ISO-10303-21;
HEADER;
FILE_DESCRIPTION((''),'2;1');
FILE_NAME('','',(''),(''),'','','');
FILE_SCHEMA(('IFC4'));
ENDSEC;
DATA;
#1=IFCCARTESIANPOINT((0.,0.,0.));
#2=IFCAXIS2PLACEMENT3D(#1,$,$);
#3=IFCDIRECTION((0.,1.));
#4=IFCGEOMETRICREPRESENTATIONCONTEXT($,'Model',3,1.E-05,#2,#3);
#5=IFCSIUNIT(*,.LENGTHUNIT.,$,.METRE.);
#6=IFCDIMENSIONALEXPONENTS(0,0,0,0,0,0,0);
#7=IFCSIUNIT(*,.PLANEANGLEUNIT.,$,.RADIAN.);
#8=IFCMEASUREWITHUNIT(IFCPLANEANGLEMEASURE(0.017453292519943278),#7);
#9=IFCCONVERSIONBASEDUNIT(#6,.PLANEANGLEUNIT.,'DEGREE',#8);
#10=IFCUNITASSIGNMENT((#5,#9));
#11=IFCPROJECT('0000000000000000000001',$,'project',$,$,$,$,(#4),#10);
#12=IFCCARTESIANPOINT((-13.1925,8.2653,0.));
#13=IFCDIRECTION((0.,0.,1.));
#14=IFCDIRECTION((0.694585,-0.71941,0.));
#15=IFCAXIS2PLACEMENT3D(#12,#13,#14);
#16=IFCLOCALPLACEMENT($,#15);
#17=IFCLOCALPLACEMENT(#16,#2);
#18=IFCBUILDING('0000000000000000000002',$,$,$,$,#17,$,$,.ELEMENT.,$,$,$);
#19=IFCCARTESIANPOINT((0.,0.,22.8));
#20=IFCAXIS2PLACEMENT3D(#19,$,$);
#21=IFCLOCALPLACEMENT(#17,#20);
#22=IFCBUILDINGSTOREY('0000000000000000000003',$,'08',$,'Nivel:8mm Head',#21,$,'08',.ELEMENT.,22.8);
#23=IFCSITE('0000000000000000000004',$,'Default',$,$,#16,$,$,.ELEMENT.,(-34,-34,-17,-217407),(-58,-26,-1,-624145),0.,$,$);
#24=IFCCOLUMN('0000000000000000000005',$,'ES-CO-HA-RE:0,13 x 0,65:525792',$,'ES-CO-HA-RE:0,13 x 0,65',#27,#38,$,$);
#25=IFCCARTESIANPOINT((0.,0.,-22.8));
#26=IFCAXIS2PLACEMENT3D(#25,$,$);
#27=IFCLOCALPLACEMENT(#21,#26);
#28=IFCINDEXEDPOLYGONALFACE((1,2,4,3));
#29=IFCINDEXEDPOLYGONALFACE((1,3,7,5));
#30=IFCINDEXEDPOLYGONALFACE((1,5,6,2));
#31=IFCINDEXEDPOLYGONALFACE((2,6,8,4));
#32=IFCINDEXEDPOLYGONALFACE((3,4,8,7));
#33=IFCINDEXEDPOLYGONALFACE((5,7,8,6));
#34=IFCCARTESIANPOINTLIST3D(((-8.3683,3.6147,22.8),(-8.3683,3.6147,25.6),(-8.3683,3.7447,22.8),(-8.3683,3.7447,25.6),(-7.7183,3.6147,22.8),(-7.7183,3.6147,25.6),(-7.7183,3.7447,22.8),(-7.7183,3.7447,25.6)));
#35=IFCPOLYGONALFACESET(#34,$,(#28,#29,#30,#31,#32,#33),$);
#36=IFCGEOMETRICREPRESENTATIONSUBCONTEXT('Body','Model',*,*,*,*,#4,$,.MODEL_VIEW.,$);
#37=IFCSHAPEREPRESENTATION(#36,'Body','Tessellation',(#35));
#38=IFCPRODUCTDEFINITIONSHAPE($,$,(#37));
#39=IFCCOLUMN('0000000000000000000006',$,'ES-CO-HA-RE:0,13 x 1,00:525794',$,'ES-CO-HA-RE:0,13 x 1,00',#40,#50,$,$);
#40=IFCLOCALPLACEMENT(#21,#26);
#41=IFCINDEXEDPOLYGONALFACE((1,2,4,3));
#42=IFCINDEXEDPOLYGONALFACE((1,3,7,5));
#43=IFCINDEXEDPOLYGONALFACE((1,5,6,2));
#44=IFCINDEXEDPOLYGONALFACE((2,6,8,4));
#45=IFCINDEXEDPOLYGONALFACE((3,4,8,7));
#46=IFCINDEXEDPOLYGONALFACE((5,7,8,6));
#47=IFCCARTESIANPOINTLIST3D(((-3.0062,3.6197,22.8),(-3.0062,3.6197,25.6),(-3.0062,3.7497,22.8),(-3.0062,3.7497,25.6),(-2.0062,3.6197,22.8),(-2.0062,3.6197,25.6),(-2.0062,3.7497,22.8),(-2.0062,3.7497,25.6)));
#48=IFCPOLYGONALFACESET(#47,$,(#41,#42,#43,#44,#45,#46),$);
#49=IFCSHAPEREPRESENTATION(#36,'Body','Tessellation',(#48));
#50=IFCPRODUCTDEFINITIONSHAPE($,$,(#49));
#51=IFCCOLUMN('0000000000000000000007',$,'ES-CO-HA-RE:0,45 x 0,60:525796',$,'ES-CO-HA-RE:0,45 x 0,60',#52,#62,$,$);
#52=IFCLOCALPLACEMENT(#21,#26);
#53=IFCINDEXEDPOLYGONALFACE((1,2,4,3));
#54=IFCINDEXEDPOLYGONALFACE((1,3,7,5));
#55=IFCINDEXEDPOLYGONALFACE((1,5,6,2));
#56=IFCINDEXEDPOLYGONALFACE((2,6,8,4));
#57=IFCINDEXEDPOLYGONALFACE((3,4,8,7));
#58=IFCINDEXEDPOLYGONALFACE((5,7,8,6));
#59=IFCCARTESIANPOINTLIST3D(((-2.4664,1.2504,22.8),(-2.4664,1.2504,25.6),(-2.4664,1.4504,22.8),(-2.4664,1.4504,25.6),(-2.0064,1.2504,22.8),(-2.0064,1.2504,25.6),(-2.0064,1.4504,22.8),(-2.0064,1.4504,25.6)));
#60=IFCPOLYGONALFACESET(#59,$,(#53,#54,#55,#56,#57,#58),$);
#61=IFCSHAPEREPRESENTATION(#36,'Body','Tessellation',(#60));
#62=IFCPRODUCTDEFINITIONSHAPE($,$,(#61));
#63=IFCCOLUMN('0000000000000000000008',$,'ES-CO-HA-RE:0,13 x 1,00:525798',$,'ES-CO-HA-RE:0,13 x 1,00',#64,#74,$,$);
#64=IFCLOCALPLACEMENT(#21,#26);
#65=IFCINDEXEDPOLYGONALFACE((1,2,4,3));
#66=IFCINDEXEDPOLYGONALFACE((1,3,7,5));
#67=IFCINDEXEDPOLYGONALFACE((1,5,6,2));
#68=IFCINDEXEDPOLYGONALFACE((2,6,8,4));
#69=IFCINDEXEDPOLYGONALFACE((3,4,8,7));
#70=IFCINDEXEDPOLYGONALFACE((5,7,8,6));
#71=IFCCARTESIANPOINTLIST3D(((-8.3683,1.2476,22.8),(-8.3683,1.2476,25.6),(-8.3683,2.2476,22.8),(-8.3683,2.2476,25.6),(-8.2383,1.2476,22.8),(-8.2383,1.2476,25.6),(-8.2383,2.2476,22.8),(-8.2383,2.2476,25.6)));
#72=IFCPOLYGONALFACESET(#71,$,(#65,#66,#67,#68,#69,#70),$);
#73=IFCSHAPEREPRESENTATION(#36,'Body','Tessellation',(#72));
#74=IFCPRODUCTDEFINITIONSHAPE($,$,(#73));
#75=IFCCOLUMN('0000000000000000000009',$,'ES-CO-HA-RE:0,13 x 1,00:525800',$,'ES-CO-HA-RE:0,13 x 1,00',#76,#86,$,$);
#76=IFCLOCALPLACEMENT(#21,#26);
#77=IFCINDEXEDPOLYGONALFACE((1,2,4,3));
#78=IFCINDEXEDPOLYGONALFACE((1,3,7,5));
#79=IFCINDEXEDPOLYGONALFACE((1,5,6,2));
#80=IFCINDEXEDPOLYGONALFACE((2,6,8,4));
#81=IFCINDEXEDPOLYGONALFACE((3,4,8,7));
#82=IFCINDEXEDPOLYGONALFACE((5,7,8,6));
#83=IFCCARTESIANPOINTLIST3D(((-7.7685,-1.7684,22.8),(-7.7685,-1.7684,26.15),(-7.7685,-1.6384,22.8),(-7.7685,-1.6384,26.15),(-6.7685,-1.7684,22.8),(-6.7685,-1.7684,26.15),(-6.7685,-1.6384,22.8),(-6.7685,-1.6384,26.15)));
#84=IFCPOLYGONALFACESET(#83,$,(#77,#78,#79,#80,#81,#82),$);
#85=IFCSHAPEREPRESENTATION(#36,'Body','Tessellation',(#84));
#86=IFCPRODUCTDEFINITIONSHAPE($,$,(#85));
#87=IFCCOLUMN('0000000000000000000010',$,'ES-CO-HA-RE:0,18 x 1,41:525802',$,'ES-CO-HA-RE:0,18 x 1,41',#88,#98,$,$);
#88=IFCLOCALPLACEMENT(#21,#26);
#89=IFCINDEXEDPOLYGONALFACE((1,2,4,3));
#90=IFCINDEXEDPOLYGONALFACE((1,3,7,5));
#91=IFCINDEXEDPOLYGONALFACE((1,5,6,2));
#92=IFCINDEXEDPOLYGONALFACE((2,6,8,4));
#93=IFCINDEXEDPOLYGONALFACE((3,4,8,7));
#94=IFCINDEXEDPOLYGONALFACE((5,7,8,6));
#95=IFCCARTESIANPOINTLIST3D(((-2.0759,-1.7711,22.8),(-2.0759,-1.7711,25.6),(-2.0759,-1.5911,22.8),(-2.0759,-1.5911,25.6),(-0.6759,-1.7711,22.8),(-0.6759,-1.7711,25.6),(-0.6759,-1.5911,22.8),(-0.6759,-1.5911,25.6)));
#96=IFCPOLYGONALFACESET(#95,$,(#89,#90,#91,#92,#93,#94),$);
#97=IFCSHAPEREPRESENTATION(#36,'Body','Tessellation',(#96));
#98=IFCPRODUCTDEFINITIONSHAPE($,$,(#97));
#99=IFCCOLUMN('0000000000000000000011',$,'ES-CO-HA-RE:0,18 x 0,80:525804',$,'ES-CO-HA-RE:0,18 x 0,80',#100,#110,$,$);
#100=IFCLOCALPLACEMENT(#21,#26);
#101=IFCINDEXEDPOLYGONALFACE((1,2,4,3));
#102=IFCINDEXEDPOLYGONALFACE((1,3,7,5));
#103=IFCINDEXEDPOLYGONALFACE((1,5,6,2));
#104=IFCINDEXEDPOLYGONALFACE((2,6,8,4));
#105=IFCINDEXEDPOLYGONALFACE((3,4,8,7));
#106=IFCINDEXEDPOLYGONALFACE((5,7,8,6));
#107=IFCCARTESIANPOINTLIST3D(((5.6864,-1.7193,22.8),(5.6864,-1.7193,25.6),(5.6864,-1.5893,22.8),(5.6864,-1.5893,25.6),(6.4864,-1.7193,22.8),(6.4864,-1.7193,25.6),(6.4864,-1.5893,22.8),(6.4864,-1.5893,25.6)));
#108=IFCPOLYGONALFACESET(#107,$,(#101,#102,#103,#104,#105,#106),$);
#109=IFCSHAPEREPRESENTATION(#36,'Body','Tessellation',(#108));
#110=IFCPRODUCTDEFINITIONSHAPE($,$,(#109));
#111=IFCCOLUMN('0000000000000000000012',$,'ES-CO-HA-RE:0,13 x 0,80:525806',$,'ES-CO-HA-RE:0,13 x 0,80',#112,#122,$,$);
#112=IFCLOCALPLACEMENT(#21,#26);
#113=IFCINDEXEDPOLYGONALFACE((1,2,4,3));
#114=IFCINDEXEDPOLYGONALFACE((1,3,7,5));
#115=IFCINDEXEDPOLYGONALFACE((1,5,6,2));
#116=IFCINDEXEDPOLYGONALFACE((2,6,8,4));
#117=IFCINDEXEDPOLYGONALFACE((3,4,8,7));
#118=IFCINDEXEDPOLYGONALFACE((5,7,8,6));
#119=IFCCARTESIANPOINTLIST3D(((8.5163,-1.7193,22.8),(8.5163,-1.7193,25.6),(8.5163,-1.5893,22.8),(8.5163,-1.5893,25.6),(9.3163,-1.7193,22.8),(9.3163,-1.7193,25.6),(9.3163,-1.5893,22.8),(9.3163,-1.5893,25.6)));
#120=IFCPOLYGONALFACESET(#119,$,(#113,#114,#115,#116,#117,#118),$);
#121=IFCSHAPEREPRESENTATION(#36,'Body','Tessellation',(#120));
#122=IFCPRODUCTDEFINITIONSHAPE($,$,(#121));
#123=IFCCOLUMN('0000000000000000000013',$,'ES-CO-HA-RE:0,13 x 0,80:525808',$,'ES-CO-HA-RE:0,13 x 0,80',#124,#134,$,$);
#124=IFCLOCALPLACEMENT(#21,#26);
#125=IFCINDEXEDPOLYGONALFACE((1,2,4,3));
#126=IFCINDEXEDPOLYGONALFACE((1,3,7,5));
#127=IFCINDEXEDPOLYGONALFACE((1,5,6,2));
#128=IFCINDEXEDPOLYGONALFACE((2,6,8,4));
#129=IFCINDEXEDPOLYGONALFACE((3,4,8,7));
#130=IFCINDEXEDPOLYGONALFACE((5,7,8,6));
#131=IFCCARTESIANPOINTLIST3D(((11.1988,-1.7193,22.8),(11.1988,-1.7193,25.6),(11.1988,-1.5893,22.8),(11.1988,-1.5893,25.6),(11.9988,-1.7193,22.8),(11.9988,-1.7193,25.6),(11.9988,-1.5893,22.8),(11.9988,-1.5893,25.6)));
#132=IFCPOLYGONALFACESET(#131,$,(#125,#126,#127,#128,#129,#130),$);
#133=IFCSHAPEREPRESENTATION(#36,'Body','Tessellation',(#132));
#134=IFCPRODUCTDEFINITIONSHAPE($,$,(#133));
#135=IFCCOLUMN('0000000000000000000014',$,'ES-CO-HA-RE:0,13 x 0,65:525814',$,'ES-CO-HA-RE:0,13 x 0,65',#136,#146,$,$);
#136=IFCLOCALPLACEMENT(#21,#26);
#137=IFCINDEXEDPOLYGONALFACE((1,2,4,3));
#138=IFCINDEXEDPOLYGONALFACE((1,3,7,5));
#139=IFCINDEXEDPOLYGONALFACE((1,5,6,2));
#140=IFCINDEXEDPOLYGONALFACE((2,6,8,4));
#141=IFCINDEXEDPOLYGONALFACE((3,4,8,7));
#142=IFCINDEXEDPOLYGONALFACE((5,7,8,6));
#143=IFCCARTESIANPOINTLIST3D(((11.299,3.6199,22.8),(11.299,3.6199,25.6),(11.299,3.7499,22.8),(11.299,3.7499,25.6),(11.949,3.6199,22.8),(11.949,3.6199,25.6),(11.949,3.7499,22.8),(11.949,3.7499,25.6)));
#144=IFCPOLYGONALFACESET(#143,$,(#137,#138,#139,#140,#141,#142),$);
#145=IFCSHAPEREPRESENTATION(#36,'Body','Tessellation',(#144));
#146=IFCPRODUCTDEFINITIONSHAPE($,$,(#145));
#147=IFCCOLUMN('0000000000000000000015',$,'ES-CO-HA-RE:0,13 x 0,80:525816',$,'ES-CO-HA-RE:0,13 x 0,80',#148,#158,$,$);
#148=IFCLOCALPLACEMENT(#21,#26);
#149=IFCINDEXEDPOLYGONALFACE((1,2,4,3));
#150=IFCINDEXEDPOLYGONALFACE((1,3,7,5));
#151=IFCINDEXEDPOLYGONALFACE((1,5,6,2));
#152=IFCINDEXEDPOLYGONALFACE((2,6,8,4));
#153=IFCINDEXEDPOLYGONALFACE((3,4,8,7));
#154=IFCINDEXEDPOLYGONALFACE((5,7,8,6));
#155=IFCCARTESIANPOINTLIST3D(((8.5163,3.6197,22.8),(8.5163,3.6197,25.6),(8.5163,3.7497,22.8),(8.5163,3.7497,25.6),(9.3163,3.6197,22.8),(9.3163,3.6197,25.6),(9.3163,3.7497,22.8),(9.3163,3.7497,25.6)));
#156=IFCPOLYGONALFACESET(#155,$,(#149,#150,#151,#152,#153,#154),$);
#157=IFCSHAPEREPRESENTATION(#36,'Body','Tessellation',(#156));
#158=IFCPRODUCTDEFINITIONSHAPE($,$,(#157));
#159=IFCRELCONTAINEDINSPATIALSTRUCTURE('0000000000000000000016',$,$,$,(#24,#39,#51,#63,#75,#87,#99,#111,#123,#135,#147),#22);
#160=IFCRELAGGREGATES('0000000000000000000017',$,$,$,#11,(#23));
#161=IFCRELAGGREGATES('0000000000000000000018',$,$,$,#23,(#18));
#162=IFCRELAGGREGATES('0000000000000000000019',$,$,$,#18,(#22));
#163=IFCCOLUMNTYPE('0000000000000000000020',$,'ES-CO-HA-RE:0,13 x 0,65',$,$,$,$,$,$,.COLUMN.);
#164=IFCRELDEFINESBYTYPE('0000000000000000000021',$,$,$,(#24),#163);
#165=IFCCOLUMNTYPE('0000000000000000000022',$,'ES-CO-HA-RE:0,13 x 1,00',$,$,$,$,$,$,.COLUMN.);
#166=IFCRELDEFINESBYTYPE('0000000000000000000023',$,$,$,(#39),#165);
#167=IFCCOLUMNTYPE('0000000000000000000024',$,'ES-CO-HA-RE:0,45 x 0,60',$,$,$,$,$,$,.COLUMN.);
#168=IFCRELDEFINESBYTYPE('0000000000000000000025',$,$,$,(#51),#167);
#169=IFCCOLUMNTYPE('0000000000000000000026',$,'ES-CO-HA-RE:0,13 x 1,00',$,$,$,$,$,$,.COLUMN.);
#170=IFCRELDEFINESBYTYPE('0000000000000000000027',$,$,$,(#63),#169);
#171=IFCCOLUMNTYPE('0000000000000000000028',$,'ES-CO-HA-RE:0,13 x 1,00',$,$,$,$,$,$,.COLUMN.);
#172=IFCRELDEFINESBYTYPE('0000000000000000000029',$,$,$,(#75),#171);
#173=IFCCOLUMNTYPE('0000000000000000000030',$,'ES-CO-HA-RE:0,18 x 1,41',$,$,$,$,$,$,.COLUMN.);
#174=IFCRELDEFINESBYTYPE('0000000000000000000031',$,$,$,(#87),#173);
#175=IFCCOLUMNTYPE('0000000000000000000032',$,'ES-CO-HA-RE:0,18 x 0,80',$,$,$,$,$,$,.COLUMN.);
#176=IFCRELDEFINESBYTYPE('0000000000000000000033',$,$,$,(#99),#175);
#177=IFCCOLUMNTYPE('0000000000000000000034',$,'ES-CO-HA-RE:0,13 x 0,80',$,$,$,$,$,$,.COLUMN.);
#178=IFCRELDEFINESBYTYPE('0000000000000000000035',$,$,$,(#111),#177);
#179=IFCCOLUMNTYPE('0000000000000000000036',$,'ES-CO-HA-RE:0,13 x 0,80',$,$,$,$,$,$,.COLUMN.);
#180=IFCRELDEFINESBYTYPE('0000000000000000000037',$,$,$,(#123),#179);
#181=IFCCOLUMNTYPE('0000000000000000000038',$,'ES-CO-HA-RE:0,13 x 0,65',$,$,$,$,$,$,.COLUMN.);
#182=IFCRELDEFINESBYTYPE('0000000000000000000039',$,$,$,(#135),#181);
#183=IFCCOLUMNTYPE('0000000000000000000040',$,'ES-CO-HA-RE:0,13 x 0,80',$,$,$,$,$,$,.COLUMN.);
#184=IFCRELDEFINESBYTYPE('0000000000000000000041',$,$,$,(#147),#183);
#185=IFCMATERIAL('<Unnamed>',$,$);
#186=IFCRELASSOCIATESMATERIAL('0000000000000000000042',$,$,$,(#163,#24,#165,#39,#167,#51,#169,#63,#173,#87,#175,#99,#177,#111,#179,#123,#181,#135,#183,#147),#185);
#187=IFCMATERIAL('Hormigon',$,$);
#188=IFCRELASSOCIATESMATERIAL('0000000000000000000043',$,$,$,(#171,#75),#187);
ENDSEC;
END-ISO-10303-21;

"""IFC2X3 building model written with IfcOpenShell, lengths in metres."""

from ifc_helpers import new_model, entity, si_unit, converted_unit, direction, frame, frame_2d, origin, origin_2d_with_axis, place, context, subcontext, project, spatial, rectangle, extrude, source, transform, mapped, material, type_object, type_shapes, element, save


model = new_model("IFC2X3")

# Units and contexts
model_context = context("Model", 3, precision=1e-05, world=origin(), true_north=direction((0.0, 1.0)))
body_context = subcontext(model_context, "Body", "Model", "MODEL_VIEW")
ifc_project = project(units=[si_unit("LENGTHUNIT", "METRE"), converted_unit("PLANEANGLEUNIT", "DEGREE", entity("IfcPlaneAngleMeasure", 0.017453292519943278), si_unit("PLANEANGLEUNIT", "RADIAN"), dimensions=[0, 0, 0, 0, 0, 0, 0])], contexts=[model_context])

# Site, building, storey
site_placement = place(None, frame((-13.1925, 8.2653, 0.0), z_axis=(0.0, 0.0, 1.0), x_axis=(0.694585, -0.71941, 0.0)))
site = spatial("IfcSite", under=ifc_project, at=site_placement, Name="Default", CompositionType="ELEMENT", RefLatitude=(-34, -34, -17, -217407), RefLongitude=(-58, -26, -1, -624145), RefElevation=0.0)
building_placement = place(site_placement, origin())
building = spatial("IfcBuilding", under=site, at=building_placement, CompositionType="ELEMENT")
storey_placement = place(building_placement, frame((0.0, 0.0, 22.8)))
storey = spatial("IfcBuildingStorey", under=building, at=storey_placement, Name="08", ObjectType="Nivel:8mm Head", LongName="08", CompositionType="ELEMENT", Elevation=22.8)

# Columns
ifc_material_1 = material(Name="<Unnamed>")
column_type_1 = type_object("IfcColumnType", Name="ES-CO-HA-RE:0,13 x 0,65", PredefinedType="COLUMN", material=ifc_material_1)
shared_shape_1 = source(origin(), body_context, "Body", "SweptSolid", [
    extrude(rectangle(XDim=0.65, YDim=0.13, at=origin_2d_with_axis()), frame((-8.0433, 3.6797, 22.8), z_axis=(0.0, 0.0, 1.0), x_axis=(-1.0, 0.0, 0.0)), (0.0, 0.0, 1.0), 2.8),
])
type_shapes(column_type_1, [shared_shape_1])
column_1_placement = place(storey_placement, frame((0.0, 0.0, -22.8)))
element("IfcColumn", 1, at=column_1_placement, inside=storey, type_object=column_type_1, material=ifc_material_1, Name="ES-CO-HA-RE:0,13 x 0,65:525792", ObjectType="ES-CO-HA-RE:0,13 x 0,65", context=body_context, shape_type="MappedRepresentation", body=[
    mapped(shared_shape_1, transform((0.0, 0.0, 0.0), scale=1.0)),
])
column_type_2 = type_object("IfcColumnType", Name="ES-CO-HA-RE:0,13 x 1,00", PredefinedType="COLUMN", material=ifc_material_1)
shared_shape_2 = source(origin(), body_context, "Body", "SweptSolid", [
    extrude(rectangle(XDim=1.0, YDim=0.13, at=frame_2d((0.0, 0.0), x_axis=(1.0, 0.0))), frame((-2.5062, 3.6847, 22.8), z_axis=(0.0, 0.0, 1.0), x_axis=(-1.0, 0.0, 0.0)), (0.0, 0.0, 1.0), 2.8),
])
type_shapes(column_type_2, [shared_shape_2])
column_2_placement = place(storey_placement, frame((0.0, 0.0, -22.8)))
element("IfcColumn", 2, at=column_2_placement, inside=storey, type_object=column_type_2, material=ifc_material_1, Name="ES-CO-HA-RE:0,13 x 1,00:525794", ObjectType="ES-CO-HA-RE:0,13 x 1,00", context=body_context, shape_type="MappedRepresentation", body=[
    mapped(shared_shape_2, transform((0.0, 0.0, 0.0), scale=1.0)),
])
column_type_3 = type_object("IfcColumnType", Name="ES-CO-HA-RE:0,45 x 0,60", PredefinedType="COLUMN", material=ifc_material_1)
shared_shape_3 = source(origin(), body_context, "Body", "SweptSolid", [
    extrude(rectangle(XDim=0.46, YDim=0.2, at=frame_2d((0.0, 0.0), x_axis=(1.0, 0.0))), frame((-2.2364, 1.3504, 22.8), z_axis=(0.0, 0.0, 1.0), x_axis=(-1.0, 0.0, 0.0)), (0.0, 0.0, 1.0), 2.8),
])
type_shapes(column_type_3, [shared_shape_3])
column_3_placement = place(storey_placement, frame((0.0, 0.0, -22.8)))
element("IfcColumn", 3, at=column_3_placement, inside=storey, type_object=column_type_3, material=ifc_material_1, Name="ES-CO-HA-RE:0,45 x 0,60:525796", ObjectType="ES-CO-HA-RE:0,45 x 0,60", context=body_context, shape_type="MappedRepresentation", body=[
    mapped(shared_shape_3, transform((0.0, 0.0, 0.0), scale=1.0)),
])
column_type_4 = type_object("IfcColumnType", Name="ES-CO-HA-RE:0,13 x 1,00", PredefinedType="COLUMN", material=ifc_material_1)
shared_shape_4 = source(origin(), body_context, "Body", "SweptSolid", [
    extrude(rectangle(XDim=1.0, YDim=0.13, at=frame_2d((0.0, 0.0), x_axis=(1.0, 0.0))), frame((-8.3033, 1.7476, 22.8), z_axis=(0.0, 0.0, 1.0), x_axis=(0.0, -1.0, 0.0)), (0.0, 0.0, 1.0), 2.8),
])
type_shapes(column_type_4, [shared_shape_4])
column_4_placement = place(storey_placement, frame((0.0, 0.0, -22.8)))
element("IfcColumn", 4, at=column_4_placement, inside=storey, type_object=column_type_4, material=ifc_material_1, Name="ES-CO-HA-RE:0,13 x 1,00:525798", ObjectType="ES-CO-HA-RE:0,13 x 1,00", context=body_context, shape_type="MappedRepresentation", body=[
    mapped(shared_shape_4, transform((0.0, 0.0, 0.0), scale=1.0)),
])
ifc_material_2 = material(Name="Hormigon")
column_type_5 = type_object("IfcColumnType", Name="ES-CO-HA-RE:0,13 x 1,00", PredefinedType="COLUMN", material=ifc_material_2)
shared_shape_5 = source(origin(), body_context, "Body", "SweptSolid", [
    extrude(rectangle(XDim=1.0, YDim=0.13, at=frame_2d((0.0, 0.0), x_axis=(1.0, 0.0))), frame((-7.2685, -1.7034, 22.8), z_axis=(0.0, 0.0, 1.0), x_axis=(-1.0, 0.0, 0.0)), (0.0, 0.0, 1.0), 3.35),
])
type_shapes(column_type_5, [shared_shape_5])
column_5_placement = place(storey_placement, frame((0.0, 0.0, -22.8)))
element("IfcColumn", 5, at=column_5_placement, inside=storey, type_object=column_type_5, material=ifc_material_2, Name="ES-CO-HA-RE:0,13 x 1,00:525800", ObjectType="ES-CO-HA-RE:0,13 x 1,00", context=body_context, shape_type="MappedRepresentation", body=[
    mapped(shared_shape_5, transform((0.0, 0.0, 0.0), scale=1.0)),
])
column_type_6 = type_object("IfcColumnType", Name="ES-CO-HA-RE:0,18 x 1,41", PredefinedType="COLUMN", material=ifc_material_1)
shared_shape_6 = source(origin(), body_context, "Body", "SweptSolid", [
    extrude(rectangle(XDim=1.4, YDim=0.18, at=frame_2d((0.0, 0.0), x_axis=(1.0, 0.0))), frame((-1.3759, -1.6811, 22.8), z_axis=(0.0, 0.0, 1.0), x_axis=(-1.0, 0.0, 0.0)), (0.0, 0.0, 1.0), 2.8),
])
type_shapes(column_type_6, [shared_shape_6])
column_6_placement = place(storey_placement, frame((0.0, 0.0, -22.8)))
element("IfcColumn", 6, at=column_6_placement, inside=storey, type_object=column_type_6, material=ifc_material_1, Name="ES-CO-HA-RE:0,18 x 1,41:525802", ObjectType="ES-CO-HA-RE:0,18 x 1,41", context=body_context, shape_type="MappedRepresentation", body=[
    mapped(shared_shape_6, transform((0.0, 0.0, 0.0), scale=1.0)),
])
column_type_7 = type_object("IfcColumnType", Name="ES-CO-HA-RE:0,18 x 0,80", PredefinedType="COLUMN", material=ifc_material_1)
shared_shape_7 = source(origin(), body_context, "Body", "SweptSolid", [
    extrude(rectangle(XDim=0.8, YDim=0.13, at=frame_2d((0.0, 0.0), x_axis=(1.0, 0.0))), frame((6.0864, -1.6543, 22.8), z_axis=(0.0, 0.0, 1.0), x_axis=(-1.0, 0.0, 0.0)), (0.0, 0.0, 1.0), 2.8),
])
type_shapes(column_type_7, [shared_shape_7])
column_7_placement = place(storey_placement, frame((0.0, 0.0, -22.8)))
element("IfcColumn", 7, at=column_7_placement, inside=storey, type_object=column_type_7, material=ifc_material_1, Name="ES-CO-HA-RE:0,18 x 0,80:525804", ObjectType="ES-CO-HA-RE:0,18 x 0,80", context=body_context, shape_type="MappedRepresentation", body=[
    mapped(shared_shape_7, transform((0.0, 0.0, 0.0), scale=1.0)),
])
column_type_8 = type_object("IfcColumnType", Name="ES-CO-HA-RE:0,13 x 0,80", PredefinedType="COLUMN", material=ifc_material_1)
shared_shape_8 = source(origin(), body_context, "Body", "SweptSolid", [
    extrude(rectangle(XDim=0.8, YDim=0.13, at=frame_2d((0.0, 0.0), x_axis=(1.0, 0.0))), frame((8.9163, -1.6543, 22.8), z_axis=(0.0, 0.0, 1.0), x_axis=(-1.0, 0.0, 0.0)), (0.0, 0.0, 1.0), 2.8),
])
type_shapes(column_type_8, [shared_shape_8])
column_8_placement = place(storey_placement, frame((0.0, 0.0, -22.8)))
element("IfcColumn", 8, at=column_8_placement, inside=storey, type_object=column_type_8, material=ifc_material_1, Name="ES-CO-HA-RE:0,13 x 0,80:525806", ObjectType="ES-CO-HA-RE:0,13 x 0,80", context=body_context, shape_type="MappedRepresentation", body=[
    mapped(shared_shape_8, transform((0.0, 0.0, 0.0), scale=1.0)),
])
column_type_9 = type_object("IfcColumnType", Name="ES-CO-HA-RE:0,13 x 0,80", PredefinedType="COLUMN", material=ifc_material_1)
shared_shape_9 = source(origin(), body_context, "Body", "SweptSolid", [
    extrude(rectangle(XDim=0.8, YDim=0.13, at=frame_2d((0.0, 0.0), x_axis=(1.0, 0.0))), frame((11.5988, -1.6543, 22.8), z_axis=(0.0, 0.0, 1.0), x_axis=(-1.0, 0.0, 0.0)), (0.0, 0.0, 1.0), 2.8),
])
type_shapes(column_type_9, [shared_shape_9])
column_9_placement = place(storey_placement, frame((0.0, 0.0, -22.8)))
element("IfcColumn", 9, at=column_9_placement, inside=storey, type_object=column_type_9, material=ifc_material_1, Name="ES-CO-HA-RE:0,13 x 0,80:525808", ObjectType="ES-CO-HA-RE:0,13 x 0,80", context=body_context, shape_type="MappedRepresentation", body=[
    mapped(shared_shape_9, transform((0.0, 0.0, 0.0), scale=1.0)),
])
column_type_10 = type_object("IfcColumnType", Name="ES-CO-HA-RE:0,13 x 0,65", PredefinedType="COLUMN", material=ifc_material_1)
shared_shape_10 = source(origin(), body_context, "Body", "SweptSolid", [
    extrude(rectangle(XDim=0.65, YDim=0.13, at=frame_2d((0.0, 0.0), x_axis=(1.0, 0.0))), frame((11.624, 3.6849, 22.8), z_axis=(0.0, 0.0, 1.0), x_axis=(-1.0, 0.0, 0.0)), (0.0, 0.0, 1.0), 2.8),
])
type_shapes(column_type_10, [shared_shape_10])
column_10_placement = place(storey_placement, frame((0.0, 0.0, -22.8)))
element("IfcColumn", 10, at=column_10_placement, inside=storey, type_object=column_type_10, material=ifc_material_1, Name="ES-CO-HA-RE:0,13 x 0,65:525814", ObjectType="ES-CO-HA-RE:0,13 x 0,65", context=body_context, shape_type="MappedRepresentation", body=[
    mapped(shared_shape_10, transform((0.0, 0.0, 0.0), scale=1.0)),
])
column_type_11 = type_object("IfcColumnType", Name="ES-CO-HA-RE:0,13 x 0,80", PredefinedType="COLUMN", material=ifc_material_1)
shared_shape_11 = source(origin(), body_context, "Body", "SweptSolid", [
    extrude(rectangle(XDim=0.8, YDim=0.13, at=origin_2d_with_axis()), frame((8.9163, 3.6847, 22.8), z_axis=(0.0, 0.0, 1.0), x_axis=(-1.0, 0.0, 0.0)), (0.0, 0.0, 1.0), 2.8),
])
type_shapes(column_type_11, [shared_shape_11])
column_11_placement = place(storey_placement, frame((0.0, 0.0, -22.8)))
element("IfcColumn", 11, at=column_11_placement, inside=storey, type_object=column_type_11, material=ifc_material_1, Name="ES-CO-HA-RE:0,13 x 0,80:525816", ObjectType="ES-CO-HA-RE:0,13 x 0,80", context=body_context, shape_type="MappedRepresentation", body=[
    mapped(shared_shape_11, transform((0.0, 0.0, 0.0), scale=1.0)),
])

save(model, "model.ifc")
